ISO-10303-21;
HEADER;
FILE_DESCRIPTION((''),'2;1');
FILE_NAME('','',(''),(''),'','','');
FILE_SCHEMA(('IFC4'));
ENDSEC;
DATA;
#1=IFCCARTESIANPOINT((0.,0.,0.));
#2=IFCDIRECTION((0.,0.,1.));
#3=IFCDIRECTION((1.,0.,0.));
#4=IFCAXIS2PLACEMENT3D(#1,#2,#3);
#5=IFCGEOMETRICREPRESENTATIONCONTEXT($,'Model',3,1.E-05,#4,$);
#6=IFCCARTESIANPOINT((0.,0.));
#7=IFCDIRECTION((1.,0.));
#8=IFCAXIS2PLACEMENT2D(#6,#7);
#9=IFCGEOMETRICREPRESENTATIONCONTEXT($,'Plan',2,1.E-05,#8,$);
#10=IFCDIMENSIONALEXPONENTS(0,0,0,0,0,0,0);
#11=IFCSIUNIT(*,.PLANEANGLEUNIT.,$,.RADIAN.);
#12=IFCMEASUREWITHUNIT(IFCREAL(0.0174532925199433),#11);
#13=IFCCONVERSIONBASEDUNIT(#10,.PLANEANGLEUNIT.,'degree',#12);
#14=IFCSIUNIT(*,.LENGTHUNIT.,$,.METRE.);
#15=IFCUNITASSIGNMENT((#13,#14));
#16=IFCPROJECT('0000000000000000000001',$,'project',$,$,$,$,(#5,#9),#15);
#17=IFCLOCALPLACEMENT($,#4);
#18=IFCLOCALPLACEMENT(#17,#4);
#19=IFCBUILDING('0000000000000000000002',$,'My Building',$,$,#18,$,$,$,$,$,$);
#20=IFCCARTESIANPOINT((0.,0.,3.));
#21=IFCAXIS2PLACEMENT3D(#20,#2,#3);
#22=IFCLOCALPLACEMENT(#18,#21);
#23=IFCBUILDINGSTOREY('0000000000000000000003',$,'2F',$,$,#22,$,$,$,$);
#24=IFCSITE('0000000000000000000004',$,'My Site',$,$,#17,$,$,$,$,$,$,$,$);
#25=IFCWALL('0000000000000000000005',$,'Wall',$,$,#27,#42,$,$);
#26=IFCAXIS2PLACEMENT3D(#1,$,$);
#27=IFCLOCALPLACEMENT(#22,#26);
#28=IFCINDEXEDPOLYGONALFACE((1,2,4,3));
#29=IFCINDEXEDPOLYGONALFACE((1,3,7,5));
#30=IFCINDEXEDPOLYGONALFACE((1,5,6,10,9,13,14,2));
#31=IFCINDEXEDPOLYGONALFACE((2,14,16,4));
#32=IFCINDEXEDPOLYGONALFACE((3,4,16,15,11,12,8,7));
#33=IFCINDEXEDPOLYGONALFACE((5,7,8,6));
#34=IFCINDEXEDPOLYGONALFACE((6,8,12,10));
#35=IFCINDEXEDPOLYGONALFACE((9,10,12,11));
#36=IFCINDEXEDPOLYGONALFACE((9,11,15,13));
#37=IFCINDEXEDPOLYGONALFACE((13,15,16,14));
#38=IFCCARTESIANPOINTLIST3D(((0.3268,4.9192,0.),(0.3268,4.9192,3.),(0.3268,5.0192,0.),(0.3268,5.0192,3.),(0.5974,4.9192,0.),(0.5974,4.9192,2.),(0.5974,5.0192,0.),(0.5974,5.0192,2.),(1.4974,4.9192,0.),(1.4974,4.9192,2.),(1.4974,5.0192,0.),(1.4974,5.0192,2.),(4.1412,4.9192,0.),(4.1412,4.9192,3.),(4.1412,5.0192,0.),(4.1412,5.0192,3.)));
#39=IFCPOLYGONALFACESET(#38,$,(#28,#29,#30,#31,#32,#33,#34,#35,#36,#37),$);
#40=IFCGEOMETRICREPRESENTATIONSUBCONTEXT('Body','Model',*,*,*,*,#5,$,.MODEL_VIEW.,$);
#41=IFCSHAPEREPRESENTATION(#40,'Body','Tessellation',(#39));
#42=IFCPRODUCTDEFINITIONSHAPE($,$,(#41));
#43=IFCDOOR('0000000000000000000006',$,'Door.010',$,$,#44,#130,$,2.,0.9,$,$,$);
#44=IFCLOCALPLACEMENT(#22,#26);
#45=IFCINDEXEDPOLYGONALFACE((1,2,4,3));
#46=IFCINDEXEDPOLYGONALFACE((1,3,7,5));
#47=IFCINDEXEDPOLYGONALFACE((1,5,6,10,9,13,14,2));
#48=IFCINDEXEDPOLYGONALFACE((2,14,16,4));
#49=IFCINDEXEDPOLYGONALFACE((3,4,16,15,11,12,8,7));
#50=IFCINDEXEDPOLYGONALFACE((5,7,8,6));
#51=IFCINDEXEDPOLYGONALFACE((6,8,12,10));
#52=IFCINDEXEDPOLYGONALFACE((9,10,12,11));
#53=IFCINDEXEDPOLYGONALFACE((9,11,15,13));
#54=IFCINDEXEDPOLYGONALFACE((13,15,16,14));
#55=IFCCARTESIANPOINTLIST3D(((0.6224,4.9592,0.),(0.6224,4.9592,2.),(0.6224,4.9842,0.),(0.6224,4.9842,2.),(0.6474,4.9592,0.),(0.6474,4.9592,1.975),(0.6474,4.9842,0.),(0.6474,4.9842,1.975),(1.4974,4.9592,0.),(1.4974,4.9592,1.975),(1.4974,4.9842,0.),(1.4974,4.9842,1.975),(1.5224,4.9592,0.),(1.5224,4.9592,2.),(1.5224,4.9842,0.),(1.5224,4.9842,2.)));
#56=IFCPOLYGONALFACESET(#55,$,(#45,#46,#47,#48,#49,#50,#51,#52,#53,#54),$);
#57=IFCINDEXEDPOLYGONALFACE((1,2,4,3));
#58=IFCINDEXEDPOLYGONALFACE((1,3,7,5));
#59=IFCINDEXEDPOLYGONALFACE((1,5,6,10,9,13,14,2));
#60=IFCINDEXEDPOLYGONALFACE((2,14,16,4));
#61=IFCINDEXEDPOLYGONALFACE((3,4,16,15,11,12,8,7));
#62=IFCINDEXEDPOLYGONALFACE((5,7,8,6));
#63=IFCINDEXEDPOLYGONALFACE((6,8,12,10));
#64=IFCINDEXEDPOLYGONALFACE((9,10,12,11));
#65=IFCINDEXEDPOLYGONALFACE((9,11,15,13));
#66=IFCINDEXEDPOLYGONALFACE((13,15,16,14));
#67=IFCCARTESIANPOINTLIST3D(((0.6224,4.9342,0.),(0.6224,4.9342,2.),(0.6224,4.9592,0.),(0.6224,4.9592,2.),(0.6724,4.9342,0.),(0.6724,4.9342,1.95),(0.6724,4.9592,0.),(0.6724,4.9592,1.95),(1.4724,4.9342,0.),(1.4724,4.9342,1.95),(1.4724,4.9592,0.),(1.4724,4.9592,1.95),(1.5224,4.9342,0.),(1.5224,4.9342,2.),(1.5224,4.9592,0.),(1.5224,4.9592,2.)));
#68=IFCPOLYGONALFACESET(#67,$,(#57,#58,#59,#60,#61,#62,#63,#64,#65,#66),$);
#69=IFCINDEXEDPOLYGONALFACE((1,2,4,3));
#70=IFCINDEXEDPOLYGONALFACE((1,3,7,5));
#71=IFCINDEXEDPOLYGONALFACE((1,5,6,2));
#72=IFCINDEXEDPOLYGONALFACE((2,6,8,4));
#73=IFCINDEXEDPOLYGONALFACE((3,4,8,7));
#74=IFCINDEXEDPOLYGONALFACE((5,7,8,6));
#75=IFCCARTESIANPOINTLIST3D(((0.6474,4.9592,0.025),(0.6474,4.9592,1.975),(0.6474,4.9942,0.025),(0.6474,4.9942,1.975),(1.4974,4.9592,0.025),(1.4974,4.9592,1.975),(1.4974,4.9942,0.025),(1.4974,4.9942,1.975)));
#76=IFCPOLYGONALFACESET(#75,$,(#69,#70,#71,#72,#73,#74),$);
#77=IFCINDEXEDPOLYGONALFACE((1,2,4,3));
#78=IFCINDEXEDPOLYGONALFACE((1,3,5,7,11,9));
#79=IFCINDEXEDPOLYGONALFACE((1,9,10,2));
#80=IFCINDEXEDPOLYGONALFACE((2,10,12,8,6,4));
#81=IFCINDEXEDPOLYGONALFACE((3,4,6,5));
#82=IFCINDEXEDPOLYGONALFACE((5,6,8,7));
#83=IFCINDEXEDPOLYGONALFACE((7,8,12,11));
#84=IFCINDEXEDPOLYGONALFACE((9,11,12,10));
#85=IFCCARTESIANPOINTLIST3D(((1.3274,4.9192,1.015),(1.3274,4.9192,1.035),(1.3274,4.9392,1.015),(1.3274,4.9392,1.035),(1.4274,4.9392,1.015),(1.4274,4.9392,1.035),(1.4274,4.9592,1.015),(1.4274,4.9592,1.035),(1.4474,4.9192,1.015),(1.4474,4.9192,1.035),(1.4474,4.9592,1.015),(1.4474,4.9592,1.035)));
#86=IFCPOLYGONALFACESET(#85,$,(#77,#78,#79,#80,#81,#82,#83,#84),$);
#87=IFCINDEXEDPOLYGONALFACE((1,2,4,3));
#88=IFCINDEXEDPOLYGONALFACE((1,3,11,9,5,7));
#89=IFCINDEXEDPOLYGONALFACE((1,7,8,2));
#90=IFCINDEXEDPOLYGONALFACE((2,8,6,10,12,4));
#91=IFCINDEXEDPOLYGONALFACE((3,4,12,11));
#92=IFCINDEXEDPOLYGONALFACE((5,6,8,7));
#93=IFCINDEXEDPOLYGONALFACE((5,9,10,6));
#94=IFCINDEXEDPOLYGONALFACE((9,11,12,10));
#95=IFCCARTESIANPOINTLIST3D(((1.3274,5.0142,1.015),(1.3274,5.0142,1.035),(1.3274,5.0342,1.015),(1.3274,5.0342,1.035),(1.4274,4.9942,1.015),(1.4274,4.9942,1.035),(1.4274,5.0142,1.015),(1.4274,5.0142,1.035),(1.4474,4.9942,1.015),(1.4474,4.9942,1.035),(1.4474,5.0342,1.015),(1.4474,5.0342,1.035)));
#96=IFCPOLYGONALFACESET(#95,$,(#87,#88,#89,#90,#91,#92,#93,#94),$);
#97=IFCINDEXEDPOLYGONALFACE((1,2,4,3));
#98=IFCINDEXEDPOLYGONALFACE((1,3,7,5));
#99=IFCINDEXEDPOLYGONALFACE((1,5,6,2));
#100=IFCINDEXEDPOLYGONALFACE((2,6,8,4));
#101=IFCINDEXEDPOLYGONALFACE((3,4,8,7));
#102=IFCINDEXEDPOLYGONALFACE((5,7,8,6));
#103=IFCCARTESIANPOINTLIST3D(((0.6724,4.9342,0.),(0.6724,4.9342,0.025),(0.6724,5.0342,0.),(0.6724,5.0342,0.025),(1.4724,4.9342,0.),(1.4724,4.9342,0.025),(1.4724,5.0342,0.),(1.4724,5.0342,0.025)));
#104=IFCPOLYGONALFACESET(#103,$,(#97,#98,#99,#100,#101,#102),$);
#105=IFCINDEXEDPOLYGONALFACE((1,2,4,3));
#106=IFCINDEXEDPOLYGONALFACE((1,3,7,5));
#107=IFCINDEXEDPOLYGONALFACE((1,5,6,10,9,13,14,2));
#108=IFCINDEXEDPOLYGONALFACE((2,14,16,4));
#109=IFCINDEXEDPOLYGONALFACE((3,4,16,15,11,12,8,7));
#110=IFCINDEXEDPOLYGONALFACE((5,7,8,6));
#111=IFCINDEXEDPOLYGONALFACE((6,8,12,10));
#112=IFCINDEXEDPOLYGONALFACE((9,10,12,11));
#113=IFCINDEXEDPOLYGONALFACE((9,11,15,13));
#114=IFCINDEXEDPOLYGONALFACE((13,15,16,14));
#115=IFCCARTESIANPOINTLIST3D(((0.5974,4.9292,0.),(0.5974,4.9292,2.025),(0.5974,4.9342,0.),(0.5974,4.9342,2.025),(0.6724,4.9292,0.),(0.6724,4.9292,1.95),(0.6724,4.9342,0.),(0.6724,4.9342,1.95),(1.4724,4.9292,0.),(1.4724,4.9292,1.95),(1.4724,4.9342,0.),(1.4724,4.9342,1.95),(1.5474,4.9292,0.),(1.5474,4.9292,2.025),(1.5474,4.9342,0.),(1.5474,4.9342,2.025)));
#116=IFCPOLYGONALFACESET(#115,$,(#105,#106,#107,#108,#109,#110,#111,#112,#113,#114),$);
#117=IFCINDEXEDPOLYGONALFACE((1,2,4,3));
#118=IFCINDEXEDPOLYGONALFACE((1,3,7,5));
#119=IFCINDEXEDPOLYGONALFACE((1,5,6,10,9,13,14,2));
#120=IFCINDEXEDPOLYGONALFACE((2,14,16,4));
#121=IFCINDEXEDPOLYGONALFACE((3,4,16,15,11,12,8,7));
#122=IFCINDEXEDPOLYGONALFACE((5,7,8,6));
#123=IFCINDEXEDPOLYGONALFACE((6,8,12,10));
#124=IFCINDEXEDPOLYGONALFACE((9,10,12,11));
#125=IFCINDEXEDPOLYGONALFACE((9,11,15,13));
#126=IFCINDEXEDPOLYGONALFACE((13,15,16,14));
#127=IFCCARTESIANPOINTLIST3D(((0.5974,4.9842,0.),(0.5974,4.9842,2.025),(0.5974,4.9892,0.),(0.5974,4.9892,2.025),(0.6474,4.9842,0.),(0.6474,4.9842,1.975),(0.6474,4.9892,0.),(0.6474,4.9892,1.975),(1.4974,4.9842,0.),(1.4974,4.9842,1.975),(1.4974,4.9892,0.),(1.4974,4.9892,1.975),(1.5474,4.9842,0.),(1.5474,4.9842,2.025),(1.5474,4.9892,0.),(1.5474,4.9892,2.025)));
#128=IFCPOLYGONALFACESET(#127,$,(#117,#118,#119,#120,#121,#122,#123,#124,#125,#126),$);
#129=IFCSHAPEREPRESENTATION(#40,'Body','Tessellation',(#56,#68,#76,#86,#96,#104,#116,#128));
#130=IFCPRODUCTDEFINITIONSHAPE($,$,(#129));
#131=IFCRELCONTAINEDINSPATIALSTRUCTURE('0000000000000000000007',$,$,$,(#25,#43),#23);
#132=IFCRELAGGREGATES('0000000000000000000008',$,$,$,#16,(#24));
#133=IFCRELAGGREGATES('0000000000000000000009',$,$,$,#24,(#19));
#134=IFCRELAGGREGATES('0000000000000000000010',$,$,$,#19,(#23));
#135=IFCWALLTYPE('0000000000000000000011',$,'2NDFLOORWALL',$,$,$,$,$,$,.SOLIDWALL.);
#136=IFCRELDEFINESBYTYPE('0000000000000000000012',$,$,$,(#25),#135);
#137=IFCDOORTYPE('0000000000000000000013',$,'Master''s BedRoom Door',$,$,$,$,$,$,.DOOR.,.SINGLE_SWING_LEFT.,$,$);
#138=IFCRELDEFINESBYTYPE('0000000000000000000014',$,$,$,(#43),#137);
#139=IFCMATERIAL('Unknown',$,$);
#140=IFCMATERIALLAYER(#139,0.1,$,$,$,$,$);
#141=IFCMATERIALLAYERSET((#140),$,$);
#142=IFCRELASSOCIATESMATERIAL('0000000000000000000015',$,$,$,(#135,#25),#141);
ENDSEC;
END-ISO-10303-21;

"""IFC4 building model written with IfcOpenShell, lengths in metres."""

from ifc_helpers import new_model, entity, si_unit, converted_unit, frame, origin_with_axes, origin_2d_with_axis, place, context, subcontext, project, spatial, line, indexed_curve, outline, extrude, shape, source, transform, mapped, material, layer, layer_set, layer_usage, type_object, type_shapes, element, fill, save


model = new_model("IFC4")

# Units and contexts
model_context = context("Model", 3, precision=1e-05, world=origin_with_axes())
plan_context = context("Plan", 2, precision=1e-05, world=origin_2d_with_axis())
body_context_1 = subcontext(model_context, "Body", "Model", "MODEL_VIEW")
body_context_2 = subcontext(plan_context, "Body", "Plan", "PLAN_VIEW")
ifc_project = project(units=[converted_unit("PLANEANGLEUNIT", "degree", entity("IfcReal", 0.0174532925199433), si_unit("PLANEANGLEUNIT", "RADIAN"), dimensions=[0, 0, 0, 0, 0, 0, 0]), si_unit("LENGTHUNIT", "METRE")], contexts=[model_context, plan_context])

# Site, building, storey
site_placement = place(None, origin_with_axes())
site = spatial("IfcSite", under=ifc_project, at=site_placement, Name="My Site")
building_placement = place(site_placement, origin_with_axes())
building = spatial("IfcBuilding", under=site, at=building_placement, Name="My Building")
storey_placement = place(building_placement, frame((0.0, 0.0, 3.0), z_axis=(0.0, 0.0, 1.0), x_axis=(1.0, 0.0, 0.0)))
storey = spatial("IfcBuildingStorey", under=building, at=storey_placement, Name="2F")

# Shared definitions
ifc_material = material(Name="Unknown")

# Shared definitions
ifc_layer_1 = layer(ifc_material, 0.1)
ifc_layer_set_1 = layer_set([ifc_layer_1])
wall_type_1 = type_object("IfcWallType", Name="2NDFLOORWALL", PredefinedType="SOLIDWALL", material=ifc_layer_set_1)

# Wall, opening, door
ifc_layer_usage_1 = layer_usage(ifc_layer_set_1, "AXIS2", "POSITIVE", 0.0)
wall_1_placement = place(storey_placement, frame((4.1412, 5.0192, 0.0), z_axis=(0.0, 0.0, 1.0), x_axis=(-1.0, 0.0, 0.0)))
wall_1 = element("IfcWall", 1, at=wall_1_placement, inside=storey, type_object=wall_type_1, material=ifc_layer_usage_1, Name="Wall", context=body_context_1, shape_type="SweptSolid", body=[
    extrude(outline(indexed_curve([(0.0, 0.0), (0.0, 0.1), (3.8144, 0.1), (3.8144, 0.0)], segments=[line(1, 2, 3, 4, 1)])), origin_with_axes(), (0.0, 0.0, 1.0), 3.0),
])
shared_shape_1 = source(origin_with_axes(), body_context_1, "Body", "SweptSolid", [
    extrude(outline(indexed_curve([(0.0, 0.0), (0.9, 0.0), (0.9, 2.0), (0.0, 2.0)], segments=[line(1, 2, 3, 4, 1)])), frame((0.0, -0.6, 0.0), z_axis=(0.0, -1.0, 0.0), x_axis=(1.0, 0.0, 0.0)), (0.0, 0.0, -1.0), 1.2),
])
opening_1_placement = place(wall_1_placement, frame((2.6438, 0.0, 0.0), z_axis=(0.0, 0.0, 1.0), x_axis=(1.0, 0.0, 0.0)))
opening_1 = element("IfcOpeningElement", 2, at=opening_1_placement, cuts=wall_1, PredefinedType="OPENING", context=body_context_1, shape_type="MappedRepresentation", body=[
    mapped(shared_shape_1, transform((0.0, 0.0, 0.0), x_axis=(1.0, 0.0, 0.0), y_axis=(0.0, 1.0, 0.0), z_axis=(0.0, 0.0, 1.0), scale=1.0)),
])
door_type_1 = type_object("IfcDoorType", Name="Master's BedRoom Door", OperationType="SINGLE_SWING_LEFT", PredefinedType="DOOR")
shared_shape_2 = source(origin_with_axes(), body_context_1, "Body", "SweptSolid", [
    extrude(outline(indexed_curve([(0.0, 0.0), (0.0, 2.0), (0.9, 2.0), (0.9, 0.0), (0.875, 0.0), (0.875, 1.975), (0.025, 1.975), (0.025, 0.0)], segments=[line(1, 2, 3, 4, 5, 6, 7, 8, 1)])), frame((0.0, 0.025, 0.0), z_axis=(0.0, -1.0, 0.0), x_axis=(1.0, 0.0, 0.0)), (0.0, 0.0, -1.0), 0.025),
    extrude(outline(indexed_curve([(0.0, 0.0), (0.0, 2.0), (0.9, 2.0), (0.9, 0.0), (0.85, 0.0), (0.85, 1.95), (0.05, 1.95), (0.05, 0.0)], segments=[line(1, 2, 3, 4, 5, 6, 7, 8, 1)])), frame((0.0, 0.0, 0.0), z_axis=(0.0, -1.0, 0.0), x_axis=(1.0, 0.0, 0.0)), (0.0, 0.0, -1.0), 0.025),
    extrude(outline(indexed_curve([(0.0, 0.0), (0.85, 0.0), (0.85, 0.035), (0.0, 0.035)], segments=[line(1, 2, 3, 4, 1)])), frame((0.025, 0.025, 0.025), z_axis=(0.0, 0.0, 1.0), x_axis=(1.0, 0.0, 0.0)), (0.0, 0.0, 1.0), 1.95),
    extrude(outline(indexed_curve([(0.0, 0.0), (0.0, -0.04), (-0.12, -0.04), (-0.12, -0.02), (-0.02, -0.02), (-0.02, 0.0)], segments=[line(1, 2, 3, 4, 5, 6, 1)])), frame((0.825, 0.025, 1.015), z_axis=(0.0, 0.0, 1.0), x_axis=(1.0, 0.0, 0.0)), (0.0, 0.0, 1.0), 0.02),
    extrude(outline(indexed_curve([(0.0, 0.0), (0.0, 0.04), (-0.12, 0.04), (-0.12, 0.02), (-0.02, 0.02), (-0.02, 0.0)], segments=[line(1, 2, 3, 4, 5, 6, 1)])), frame((0.825, 0.06, 1.015), z_axis=(0.0, 0.0, 1.0), x_axis=(1.0, 0.0, 0.0)), (0.0, 0.0, 1.0), 0.02),
    extrude(outline(indexed_curve([(0.0, 0.0), (0.8, 0.0), (0.8, 0.1), (0.0, 0.1)], segments=[line(1, 2, 3, 4, 1)])), frame((0.05, 0.0, 0.0), z_axis=(0.0, 0.0, 1.0), x_axis=(1.0, 0.0, 0.0)), (0.0, 0.0, 1.0), 0.025),
    extrude(outline(indexed_curve([(0.0, 0.0), (0.0, 2.025), (0.95, 2.025), (0.95, 0.0), (0.875, 0.0), (0.875, 1.95), (0.075, 1.95), (0.075, 0.0)], segments=[line(1, 2, 3, 4, 5, 6, 7, 8, 1)])), frame((-0.025, -0.005, 0.0), z_axis=(0.0, -1.0, 0.0), x_axis=(1.0, 0.0, 0.0)), (0.0, 0.0, -1.0), 0.005),
    extrude(outline(indexed_curve([(0.0, 0.0), (0.0, 2.025), (0.95, 2.025), (0.95, 0.0), (0.9, 0.0), (0.9, 1.975), (0.05, 1.975), (0.05, 0.0)], segments=[line(1, 2, 3, 4, 5, 6, 7, 8, 1)])), frame((-0.025, 0.05, 0.0), z_axis=(0.0, -1.0, 0.0), x_axis=(1.0, 0.0, 0.0)), (0.0, 0.0, -1.0), 0.005),
])
shared_shape_3 = source(origin_with_axes(), body_context_2, "Body", "Curve2D", [
    entity("IfcIndexedPolyCurve", entity("IfcCartesianPointList2D", [[0.0, 0.0], [0.0, 0.05], [0.025, 0.05], [0.025, 0.025], [0.05, 0.025], [0.05, 0.0]]), [entity("IfcLineIndex", [1, 2, 3, 4, 5, 6, 1])]),
    entity("IfcIndexedPolyCurve", entity("IfcCartesianPointList2D", [[0.9, 0.0], [0.9, 0.05], [0.875, 0.05], [0.875, 0.025], [0.85, 0.025], [0.85, 0.0]]), [entity("IfcLineIndex", [1, 2, 3, 4, 5, 6, 1])]),
    entity("IfcTrimmedCurve", entity("IfcEllipse", entity("IfcAxis2Placement2D", entity("IfcCartesianPoint", [0.06, 0.05]), entity("IfcDirection", [1.0, 0.0])), 0.815, 0.85), [entity("IfcCartesianPoint", [0.875, 0.05])], [entity("IfcCartesianPoint", [0.06, 0.9])], True, "CARTESIAN"),
    entity("IfcIndexedPolyCurve", entity("IfcCartesianPointList2D", [[0.025, 0.05], [0.06, 0.05], [0.06, 0.9], [0.025, 0.9]]), [entity("IfcLineIndex", [1, 2, 3, 4, 1])]),
])
type_shapes(door_type_1, [shared_shape_2, shared_shape_3])
door_1_placement = place(opening_1_placement, frame((0.875, 0.085, 0.0), z_axis=(0.0, 0.0, 1.0), x_axis=(-1.0, 0.0, 0.0)))
door_1 = element("IfcDoor", 3, at=door_1_placement, inside=storey, type_object=door_type_1, Name="Door.010", OverallHeight=2.0, OverallWidth=0.9, shapes=[
    shape(body_context_1, "Body", "MappedRepresentation", [mapped(shared_shape_2, transform((0.0, 0.0, 0.0), x_axis=(1.0, 0.0, 0.0), y_axis=(0.0, 1.0, 0.0), z_axis=(0.0, 0.0, 1.0), scale=1.0))]),
    shape(body_context_2, "Body", "MappedRepresentation", [mapped(shared_shape_3, transform((0.0, 0.0, 0.0), x_axis=(1.0, 0.0, 0.0), y_axis=(0.0, 1.0, 0.0), z_axis=(0.0, 0.0, 1.0), scale=1.0))]),
])
fill(opening_1, door_1)

save(model, "model.ifc")
